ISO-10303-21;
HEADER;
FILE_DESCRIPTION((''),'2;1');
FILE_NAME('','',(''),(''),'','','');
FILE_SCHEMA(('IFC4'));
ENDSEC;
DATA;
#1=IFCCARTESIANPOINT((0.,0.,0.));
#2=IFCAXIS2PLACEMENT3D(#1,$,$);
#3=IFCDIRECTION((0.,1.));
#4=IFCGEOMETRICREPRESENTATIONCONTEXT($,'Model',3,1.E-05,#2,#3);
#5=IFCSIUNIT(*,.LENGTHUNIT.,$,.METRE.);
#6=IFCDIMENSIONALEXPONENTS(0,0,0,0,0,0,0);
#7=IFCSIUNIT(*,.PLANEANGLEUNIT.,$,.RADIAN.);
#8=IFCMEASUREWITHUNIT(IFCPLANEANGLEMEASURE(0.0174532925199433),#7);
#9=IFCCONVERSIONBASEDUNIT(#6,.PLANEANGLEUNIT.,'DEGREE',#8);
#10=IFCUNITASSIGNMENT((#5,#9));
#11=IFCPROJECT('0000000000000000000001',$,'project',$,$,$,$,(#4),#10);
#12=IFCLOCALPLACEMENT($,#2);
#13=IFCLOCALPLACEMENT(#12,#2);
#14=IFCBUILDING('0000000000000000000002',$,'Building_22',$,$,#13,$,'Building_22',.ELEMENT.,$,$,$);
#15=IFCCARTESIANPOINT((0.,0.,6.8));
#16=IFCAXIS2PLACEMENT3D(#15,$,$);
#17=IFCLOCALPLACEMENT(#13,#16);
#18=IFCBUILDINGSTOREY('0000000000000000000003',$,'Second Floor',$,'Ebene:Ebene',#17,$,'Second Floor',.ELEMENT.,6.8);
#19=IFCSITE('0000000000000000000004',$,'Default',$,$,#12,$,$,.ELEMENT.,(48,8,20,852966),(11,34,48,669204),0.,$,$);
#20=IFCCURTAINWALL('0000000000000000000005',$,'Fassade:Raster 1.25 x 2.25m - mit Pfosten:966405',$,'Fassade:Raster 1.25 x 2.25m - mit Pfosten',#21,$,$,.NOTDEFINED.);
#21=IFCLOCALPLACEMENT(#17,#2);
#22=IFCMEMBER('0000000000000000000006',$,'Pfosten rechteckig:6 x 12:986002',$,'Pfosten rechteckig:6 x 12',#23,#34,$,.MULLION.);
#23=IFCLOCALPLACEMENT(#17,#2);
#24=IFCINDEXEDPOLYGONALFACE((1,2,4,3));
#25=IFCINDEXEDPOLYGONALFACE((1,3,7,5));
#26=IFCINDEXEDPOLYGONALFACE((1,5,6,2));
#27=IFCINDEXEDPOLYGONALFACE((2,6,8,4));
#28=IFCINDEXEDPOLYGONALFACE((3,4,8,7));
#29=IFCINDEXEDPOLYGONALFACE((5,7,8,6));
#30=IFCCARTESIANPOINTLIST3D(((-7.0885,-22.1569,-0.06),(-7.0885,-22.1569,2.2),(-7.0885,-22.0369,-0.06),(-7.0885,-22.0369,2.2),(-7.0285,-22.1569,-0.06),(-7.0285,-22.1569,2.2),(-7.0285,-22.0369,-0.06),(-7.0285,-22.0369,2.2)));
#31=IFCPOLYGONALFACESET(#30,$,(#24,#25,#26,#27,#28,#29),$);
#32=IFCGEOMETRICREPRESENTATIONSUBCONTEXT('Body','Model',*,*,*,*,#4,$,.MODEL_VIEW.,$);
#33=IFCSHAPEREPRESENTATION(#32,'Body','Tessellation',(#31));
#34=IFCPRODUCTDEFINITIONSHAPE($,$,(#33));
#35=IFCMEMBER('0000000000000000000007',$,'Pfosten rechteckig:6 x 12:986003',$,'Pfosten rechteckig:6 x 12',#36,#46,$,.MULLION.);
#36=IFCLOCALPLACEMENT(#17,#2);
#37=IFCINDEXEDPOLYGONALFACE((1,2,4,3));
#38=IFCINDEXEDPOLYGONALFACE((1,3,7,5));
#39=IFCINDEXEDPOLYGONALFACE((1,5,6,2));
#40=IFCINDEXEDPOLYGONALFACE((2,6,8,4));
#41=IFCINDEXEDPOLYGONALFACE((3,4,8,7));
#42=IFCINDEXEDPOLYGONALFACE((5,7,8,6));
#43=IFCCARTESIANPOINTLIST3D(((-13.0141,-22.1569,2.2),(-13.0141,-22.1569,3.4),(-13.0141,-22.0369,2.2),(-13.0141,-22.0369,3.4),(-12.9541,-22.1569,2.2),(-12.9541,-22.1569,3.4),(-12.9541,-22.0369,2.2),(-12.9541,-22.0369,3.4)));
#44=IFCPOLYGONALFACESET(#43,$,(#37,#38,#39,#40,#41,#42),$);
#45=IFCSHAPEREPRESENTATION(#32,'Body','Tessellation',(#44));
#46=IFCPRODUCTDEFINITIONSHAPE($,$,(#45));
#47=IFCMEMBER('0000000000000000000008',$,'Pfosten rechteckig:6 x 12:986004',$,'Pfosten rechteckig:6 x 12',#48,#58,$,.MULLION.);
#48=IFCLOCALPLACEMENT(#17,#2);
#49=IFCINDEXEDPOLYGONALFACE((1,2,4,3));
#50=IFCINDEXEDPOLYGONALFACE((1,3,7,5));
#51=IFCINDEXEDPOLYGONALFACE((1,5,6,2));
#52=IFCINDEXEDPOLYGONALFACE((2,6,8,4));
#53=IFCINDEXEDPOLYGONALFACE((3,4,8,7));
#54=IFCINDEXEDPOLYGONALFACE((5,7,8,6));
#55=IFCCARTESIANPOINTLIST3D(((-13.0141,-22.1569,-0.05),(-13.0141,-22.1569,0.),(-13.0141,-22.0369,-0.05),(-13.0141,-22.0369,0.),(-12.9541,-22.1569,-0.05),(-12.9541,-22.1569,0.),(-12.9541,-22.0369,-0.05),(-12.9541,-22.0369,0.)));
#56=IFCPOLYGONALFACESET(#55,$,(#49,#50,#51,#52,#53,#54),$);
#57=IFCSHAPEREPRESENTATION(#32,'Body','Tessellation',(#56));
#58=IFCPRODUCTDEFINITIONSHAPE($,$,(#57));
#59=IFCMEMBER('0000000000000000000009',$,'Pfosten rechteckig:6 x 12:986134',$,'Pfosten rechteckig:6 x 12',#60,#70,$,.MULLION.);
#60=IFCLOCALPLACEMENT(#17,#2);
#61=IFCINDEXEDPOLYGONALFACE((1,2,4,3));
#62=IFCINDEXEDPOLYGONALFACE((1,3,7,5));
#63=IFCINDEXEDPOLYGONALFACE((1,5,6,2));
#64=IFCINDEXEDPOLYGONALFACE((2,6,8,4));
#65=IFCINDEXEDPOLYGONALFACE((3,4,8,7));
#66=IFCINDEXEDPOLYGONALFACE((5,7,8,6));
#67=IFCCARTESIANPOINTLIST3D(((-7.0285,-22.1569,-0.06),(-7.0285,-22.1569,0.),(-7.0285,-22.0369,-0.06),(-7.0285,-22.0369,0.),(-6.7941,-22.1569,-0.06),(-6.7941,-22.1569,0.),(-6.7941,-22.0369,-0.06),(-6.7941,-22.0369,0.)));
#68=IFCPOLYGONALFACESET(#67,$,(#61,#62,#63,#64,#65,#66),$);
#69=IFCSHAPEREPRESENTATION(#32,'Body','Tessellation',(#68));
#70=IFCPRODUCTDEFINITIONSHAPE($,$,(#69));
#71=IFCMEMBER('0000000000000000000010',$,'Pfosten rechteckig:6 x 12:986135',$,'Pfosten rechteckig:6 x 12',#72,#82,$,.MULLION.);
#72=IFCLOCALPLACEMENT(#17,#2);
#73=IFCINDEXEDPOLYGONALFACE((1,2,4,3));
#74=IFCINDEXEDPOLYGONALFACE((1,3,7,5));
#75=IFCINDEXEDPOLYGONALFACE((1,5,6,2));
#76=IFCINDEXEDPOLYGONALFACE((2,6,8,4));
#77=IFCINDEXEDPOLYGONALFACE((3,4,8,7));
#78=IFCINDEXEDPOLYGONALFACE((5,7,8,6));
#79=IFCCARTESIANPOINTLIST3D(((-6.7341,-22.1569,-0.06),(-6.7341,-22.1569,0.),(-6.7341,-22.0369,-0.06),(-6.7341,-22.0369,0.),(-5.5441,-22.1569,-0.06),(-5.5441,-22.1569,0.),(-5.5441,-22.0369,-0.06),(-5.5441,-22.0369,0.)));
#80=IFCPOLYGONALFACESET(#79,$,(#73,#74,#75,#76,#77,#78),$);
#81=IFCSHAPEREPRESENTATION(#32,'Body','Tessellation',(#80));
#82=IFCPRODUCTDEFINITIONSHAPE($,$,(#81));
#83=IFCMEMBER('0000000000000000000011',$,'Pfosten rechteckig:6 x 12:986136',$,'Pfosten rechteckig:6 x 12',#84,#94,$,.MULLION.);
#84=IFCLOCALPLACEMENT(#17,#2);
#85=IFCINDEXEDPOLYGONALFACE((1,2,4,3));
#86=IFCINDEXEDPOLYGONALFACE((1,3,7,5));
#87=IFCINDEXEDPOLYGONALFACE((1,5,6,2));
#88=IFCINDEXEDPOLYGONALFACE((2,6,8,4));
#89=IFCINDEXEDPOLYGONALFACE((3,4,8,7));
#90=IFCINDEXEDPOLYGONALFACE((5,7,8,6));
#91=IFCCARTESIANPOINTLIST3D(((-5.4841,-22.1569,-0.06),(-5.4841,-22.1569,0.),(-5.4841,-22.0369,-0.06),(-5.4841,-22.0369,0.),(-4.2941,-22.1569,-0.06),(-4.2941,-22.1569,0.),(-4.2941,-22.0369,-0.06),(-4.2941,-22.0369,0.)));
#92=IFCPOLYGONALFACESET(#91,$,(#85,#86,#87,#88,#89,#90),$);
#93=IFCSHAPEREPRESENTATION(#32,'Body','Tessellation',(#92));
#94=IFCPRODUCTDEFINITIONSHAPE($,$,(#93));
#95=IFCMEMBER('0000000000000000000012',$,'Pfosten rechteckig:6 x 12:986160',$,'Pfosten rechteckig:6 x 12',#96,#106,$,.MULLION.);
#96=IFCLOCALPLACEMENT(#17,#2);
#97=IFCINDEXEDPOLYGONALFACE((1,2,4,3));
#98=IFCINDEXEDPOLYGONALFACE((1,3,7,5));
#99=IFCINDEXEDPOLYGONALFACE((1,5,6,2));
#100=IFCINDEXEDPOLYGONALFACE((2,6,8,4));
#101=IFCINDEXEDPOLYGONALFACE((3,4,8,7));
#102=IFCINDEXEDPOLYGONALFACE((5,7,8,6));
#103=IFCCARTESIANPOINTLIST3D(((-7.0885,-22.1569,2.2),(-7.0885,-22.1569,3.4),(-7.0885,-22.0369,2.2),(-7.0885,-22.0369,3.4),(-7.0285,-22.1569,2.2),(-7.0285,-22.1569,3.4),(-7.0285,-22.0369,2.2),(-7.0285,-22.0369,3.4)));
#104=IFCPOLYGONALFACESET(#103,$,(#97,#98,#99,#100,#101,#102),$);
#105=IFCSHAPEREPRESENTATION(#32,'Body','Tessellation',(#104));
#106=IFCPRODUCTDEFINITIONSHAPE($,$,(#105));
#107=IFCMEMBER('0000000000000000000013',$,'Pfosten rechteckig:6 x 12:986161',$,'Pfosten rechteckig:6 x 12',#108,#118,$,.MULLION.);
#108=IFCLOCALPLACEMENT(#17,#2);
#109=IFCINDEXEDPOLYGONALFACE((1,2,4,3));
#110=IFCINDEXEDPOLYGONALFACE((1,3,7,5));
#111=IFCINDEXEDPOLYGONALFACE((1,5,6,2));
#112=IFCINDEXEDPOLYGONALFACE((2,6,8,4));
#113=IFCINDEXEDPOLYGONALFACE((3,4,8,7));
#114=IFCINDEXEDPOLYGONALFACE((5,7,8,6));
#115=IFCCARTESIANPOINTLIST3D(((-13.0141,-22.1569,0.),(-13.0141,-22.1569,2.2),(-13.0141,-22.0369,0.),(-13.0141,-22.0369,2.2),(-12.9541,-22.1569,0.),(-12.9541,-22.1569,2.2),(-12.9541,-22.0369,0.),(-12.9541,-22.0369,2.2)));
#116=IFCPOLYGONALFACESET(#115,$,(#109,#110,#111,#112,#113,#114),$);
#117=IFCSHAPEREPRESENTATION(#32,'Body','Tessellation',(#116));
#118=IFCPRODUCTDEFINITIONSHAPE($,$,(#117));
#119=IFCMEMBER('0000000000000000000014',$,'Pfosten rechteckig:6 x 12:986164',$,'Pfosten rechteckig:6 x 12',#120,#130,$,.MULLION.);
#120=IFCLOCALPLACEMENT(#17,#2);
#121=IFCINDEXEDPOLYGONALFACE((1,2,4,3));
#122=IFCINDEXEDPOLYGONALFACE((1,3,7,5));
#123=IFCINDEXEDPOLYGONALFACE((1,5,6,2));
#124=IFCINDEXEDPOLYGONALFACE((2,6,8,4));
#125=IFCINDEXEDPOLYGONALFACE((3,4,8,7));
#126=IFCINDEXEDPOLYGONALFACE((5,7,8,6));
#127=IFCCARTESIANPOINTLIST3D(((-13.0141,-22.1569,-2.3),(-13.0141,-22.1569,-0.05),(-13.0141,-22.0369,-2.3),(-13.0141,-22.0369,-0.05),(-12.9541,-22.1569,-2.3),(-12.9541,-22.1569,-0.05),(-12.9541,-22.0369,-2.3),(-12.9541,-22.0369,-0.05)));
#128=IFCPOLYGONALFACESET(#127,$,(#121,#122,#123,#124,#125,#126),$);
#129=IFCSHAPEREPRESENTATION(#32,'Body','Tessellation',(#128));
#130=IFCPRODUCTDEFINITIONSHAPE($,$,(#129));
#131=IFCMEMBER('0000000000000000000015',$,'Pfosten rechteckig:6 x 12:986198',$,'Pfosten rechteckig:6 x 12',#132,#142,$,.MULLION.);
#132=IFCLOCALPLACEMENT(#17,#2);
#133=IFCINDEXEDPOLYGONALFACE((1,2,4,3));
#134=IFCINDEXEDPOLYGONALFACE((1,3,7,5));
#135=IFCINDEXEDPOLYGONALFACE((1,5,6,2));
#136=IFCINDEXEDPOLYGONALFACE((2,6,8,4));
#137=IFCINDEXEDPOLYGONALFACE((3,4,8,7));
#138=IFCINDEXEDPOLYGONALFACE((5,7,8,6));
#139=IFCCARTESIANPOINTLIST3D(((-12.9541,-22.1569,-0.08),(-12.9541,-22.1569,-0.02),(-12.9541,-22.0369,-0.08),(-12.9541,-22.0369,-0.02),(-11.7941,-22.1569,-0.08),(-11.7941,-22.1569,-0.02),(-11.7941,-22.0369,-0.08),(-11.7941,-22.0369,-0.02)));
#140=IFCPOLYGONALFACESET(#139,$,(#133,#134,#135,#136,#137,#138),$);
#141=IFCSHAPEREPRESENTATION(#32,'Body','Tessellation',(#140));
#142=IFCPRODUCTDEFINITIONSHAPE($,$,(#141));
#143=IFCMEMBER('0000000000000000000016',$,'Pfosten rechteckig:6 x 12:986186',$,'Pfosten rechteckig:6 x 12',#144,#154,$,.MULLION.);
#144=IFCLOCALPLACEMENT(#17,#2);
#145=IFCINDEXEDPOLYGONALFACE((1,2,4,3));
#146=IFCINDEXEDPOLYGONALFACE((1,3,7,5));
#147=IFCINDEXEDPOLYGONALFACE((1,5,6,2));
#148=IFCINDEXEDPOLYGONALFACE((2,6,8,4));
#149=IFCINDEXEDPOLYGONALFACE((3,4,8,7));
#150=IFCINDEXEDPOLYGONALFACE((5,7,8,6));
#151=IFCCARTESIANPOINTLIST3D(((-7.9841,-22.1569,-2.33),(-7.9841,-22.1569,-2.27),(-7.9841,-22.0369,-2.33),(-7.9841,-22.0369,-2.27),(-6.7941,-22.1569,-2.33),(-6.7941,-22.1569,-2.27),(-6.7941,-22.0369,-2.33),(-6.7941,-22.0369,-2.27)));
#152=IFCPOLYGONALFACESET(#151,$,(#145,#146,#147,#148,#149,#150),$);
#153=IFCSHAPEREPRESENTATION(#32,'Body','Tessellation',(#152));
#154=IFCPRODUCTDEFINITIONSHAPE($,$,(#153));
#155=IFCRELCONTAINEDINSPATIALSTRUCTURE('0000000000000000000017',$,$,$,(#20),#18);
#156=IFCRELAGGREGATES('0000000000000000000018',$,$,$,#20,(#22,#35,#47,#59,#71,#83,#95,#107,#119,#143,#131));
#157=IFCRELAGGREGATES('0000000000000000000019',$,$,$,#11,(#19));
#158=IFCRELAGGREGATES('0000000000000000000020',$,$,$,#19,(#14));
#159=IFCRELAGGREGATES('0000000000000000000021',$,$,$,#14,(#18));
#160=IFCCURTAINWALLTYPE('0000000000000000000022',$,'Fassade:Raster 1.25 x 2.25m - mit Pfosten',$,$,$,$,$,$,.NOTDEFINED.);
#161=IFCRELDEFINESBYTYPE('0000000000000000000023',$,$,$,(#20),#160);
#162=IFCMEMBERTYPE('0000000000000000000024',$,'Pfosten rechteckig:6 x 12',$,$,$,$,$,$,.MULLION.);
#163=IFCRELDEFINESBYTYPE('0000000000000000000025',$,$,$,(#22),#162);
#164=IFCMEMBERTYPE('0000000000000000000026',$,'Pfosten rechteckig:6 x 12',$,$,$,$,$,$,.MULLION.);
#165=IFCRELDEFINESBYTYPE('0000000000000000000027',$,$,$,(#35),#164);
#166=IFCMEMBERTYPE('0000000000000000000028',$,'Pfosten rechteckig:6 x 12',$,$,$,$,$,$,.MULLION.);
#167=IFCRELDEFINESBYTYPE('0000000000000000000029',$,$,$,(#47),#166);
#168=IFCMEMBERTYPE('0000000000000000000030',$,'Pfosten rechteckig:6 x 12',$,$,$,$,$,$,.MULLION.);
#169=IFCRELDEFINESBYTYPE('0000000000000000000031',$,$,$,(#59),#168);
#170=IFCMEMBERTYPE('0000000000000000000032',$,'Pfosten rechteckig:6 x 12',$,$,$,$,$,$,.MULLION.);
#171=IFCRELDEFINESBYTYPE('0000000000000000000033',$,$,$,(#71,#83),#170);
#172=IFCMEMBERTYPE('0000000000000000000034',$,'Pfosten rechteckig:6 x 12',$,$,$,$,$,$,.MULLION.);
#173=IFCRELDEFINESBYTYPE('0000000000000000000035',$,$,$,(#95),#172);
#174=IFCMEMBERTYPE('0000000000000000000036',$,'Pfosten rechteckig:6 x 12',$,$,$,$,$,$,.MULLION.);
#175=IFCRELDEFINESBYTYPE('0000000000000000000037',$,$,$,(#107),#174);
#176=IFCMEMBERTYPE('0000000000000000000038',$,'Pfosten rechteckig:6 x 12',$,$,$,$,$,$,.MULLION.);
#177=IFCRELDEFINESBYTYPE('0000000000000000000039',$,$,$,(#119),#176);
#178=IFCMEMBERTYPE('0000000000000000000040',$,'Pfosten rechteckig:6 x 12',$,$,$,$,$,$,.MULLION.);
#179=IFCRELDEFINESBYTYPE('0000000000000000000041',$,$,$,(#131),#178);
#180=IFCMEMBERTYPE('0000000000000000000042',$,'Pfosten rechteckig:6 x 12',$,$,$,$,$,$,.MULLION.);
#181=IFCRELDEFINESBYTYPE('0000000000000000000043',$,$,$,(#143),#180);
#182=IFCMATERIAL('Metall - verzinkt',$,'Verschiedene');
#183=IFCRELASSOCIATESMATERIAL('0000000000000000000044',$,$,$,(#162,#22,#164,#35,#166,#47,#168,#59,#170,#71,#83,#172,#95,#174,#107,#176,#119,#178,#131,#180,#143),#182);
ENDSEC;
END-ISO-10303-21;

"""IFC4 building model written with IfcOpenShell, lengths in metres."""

from ifc_helpers import new_model, entity, si_unit, converted_unit, direction, frame, origin, place, context, subcontext, project, spatial, indexed_curve, outline, extrude, source, transform, mapped, material, type_object, type_shapes, element, aggregate, save


model = new_model("IFC4")

# Units and contexts
model_context = context("Model", 3, precision=1e-05, world=origin(), true_north=direction((0.0, 1.0)))
body_context = subcontext(model_context, "Body", "Model", "MODEL_VIEW")
ifc_project = project(units=[si_unit("LENGTHUNIT", "METRE"), converted_unit("PLANEANGLEUNIT", "DEGREE", entity("IfcPlaneAngleMeasure", 0.0174532925199433), si_unit("PLANEANGLEUNIT", "RADIAN"), dimensions=[0, 0, 0, 0, 0, 0, 0])], contexts=[model_context])

# Site, building, storey
site_placement = place(None, origin())
site = spatial("IfcSite", under=ifc_project, at=site_placement, Name="Default", CompositionType="ELEMENT", RefLatitude=(48, 8, 20, 852966), RefLongitude=(11, 34, 48, 669204), RefElevation=0.0)
building_placement = place(site_placement, origin())
building = spatial("IfcBuilding", under=site, at=building_placement, Name="Building_22", LongName="Building_22", CompositionType="ELEMENT")
storey_placement = place(building_placement, frame((0.0, 0.0, 6.8)))
storey = spatial("IfcBuildingStorey", under=building, at=storey_placement, Name="Second Floor", ObjectType="Ebene:Ebene", LongName="Second Floor", CompositionType="ELEMENT", Elevation=6.8)

# Curtain wall, members
curtain_wall_type = type_object("IfcCurtainWallType", Name="Fassade:Raster 1.25 x 2.25m - mit Pfosten", PredefinedType="NOTDEFINED")
curtain_wall_placement = place(storey_placement, frame((0.0, 0.0, -6.8)))
curtain_wall = element("IfcCurtainWall", 1, at=curtain_wall_placement, inside=storey, type_object=curtain_wall_type, Name="Fassade:Raster 1.25 x 2.25m - mit Pfosten:966405", ObjectType="Fassade:Raster 1.25 x 2.25m - mit Pfosten", PredefinedType="NOTDEFINED")
ifc_material_1 = material(Name="Metall - verzinkt", Category="Verschiedene")
member_type_1 = type_object("IfcMemberType", Name="Pfosten rechteckig:6 x 12", PredefinedType="MULLION", material=ifc_material_1)
shared_shape_1 = source(origin(), body_context, "Body", "SweptSolid", [
    extrude(outline(indexed_curve([(-0.03, -0.06), (0.03, -0.06), (0.03, 0.06), (-0.03, 0.06), (-0.03, -0.06)], self_intersect=False)), frame((-0.03, 0.0, -2.26), z_axis=(0.0, 0.0, 1.0), x_axis=(-1.0, 0.0, 0.0)), (0.0, 0.0, 1.0), 2.26),
])
type_shapes(member_type_1, [shared_shape_1])
member_1_placement = place(curtain_wall_placement, frame((-7.0285, -22.0969, 6.74), z_axis=(0.0, 0.0, -1.0), x_axis=(1.0, 0.0, 0.0)))
member_1 = element("IfcMember", 2, at=member_1_placement, type_object=member_type_1, material=ifc_material_1, Name="Pfosten rechteckig:6 x 12:986002", ObjectType="Pfosten rechteckig:6 x 12", PredefinedType="MULLION", context=body_context, shape_type="MappedRepresentation", body=[
    mapped(shared_shape_1, transform((0.0, 0.0, 0.0), scale=1.0)),
])
member_type_2 = type_object("IfcMemberType", Name="Pfosten rechteckig:6 x 12", PredefinedType="MULLION", material=ifc_material_1)
shared_shape_2 = source(origin(), body_context, "Body", "SweptSolid", [
    extrude(outline(indexed_curve([(-0.03, -0.06), (0.03, -0.06), (0.03, 0.06), (-0.03, 0.06), (-0.03, -0.06)], self_intersect=False)), frame((-0.03, 0.0, -1.2), z_axis=(0.0, 0.0, 1.0), x_axis=(-1.0, 0.0, 0.0)), (0.0, 0.0, 1.0), 1.2),
])
type_shapes(member_type_2, [shared_shape_2])
member_2_placement = place(curtain_wall_placement, frame((-13.0141, -22.0969, 10.2), z_axis=(0.0, 0.0, 1.0), x_axis=(-1.0, 0.0, 0.0)))
member_2 = element("IfcMember", 3, at=member_2_placement, type_object=member_type_2, material=ifc_material_1, Name="Pfosten rechteckig:6 x 12:986003", ObjectType="Pfosten rechteckig:6 x 12", PredefinedType="MULLION", context=body_context, shape_type="MappedRepresentation", body=[
    mapped(shared_shape_2, transform((0.0, 0.0, 0.0), scale=1.0)),
])
member_type_3 = type_object("IfcMemberType", Name="Pfosten rechteckig:6 x 12", PredefinedType="MULLION", material=ifc_material_1)
shared_shape_3 = source(origin(), body_context, "Body", "SweptSolid", [
    extrude(outline(indexed_curve([(-0.03, -0.06), (0.03, -0.06), (0.03, 0.06), (-0.03, 0.06), (-0.03, -0.06)], self_intersect=False)), frame((-0.03, 0.0, -0.05), z_axis=(0.0, 0.0, 1.0), x_axis=(-1.0, 0.0, 0.0)), (0.0, 0.0, 1.0), 0.05),
])
type_shapes(member_type_3, [shared_shape_3])
member_3_placement = place(curtain_wall_placement, frame((-13.0141, -22.0969, 6.8), z_axis=(0.0, 0.0, 1.0), x_axis=(-1.0, 0.0, 0.0)))
member_3 = element("IfcMember", 4, at=member_3_placement, type_object=member_type_3, material=ifc_material_1, Name="Pfosten rechteckig:6 x 12:986004", ObjectType="Pfosten rechteckig:6 x 12", PredefinedType="MULLION", context=body_context, shape_type="MappedRepresentation", body=[
    mapped(shared_shape_3, transform((0.0, 0.0, 0.0), scale=1.0)),
])
member_type_4 = type_object("IfcMemberType", Name="Pfosten rechteckig:6 x 12", PredefinedType="MULLION", material=ifc_material_1)
shared_shape_4 = source(origin(), body_context, "Body", "SweptSolid", [
    extrude(outline(indexed_curve([(-0.03, -0.06), (0.03, -0.06), (0.03, 0.06), (-0.03, 0.06), (-0.03, -0.06)], self_intersect=False)), frame((-0.03, 0.0, -0.2344), z_axis=(0.0, 0.0, 1.0), x_axis=(-1.0, 0.0, 0.0)), (0.0, 0.0, 1.0), 0.2344),
])
type_shapes(member_type_4, [shared_shape_4])
member_4_placement = place(curtain_wall_placement, frame((-6.7941, -22.0969, 6.8), z_axis=(1.0, 0.0, 0.0), x_axis=(0.0, 0.0, 1.0)))
member_4 = element("IfcMember", 5, at=member_4_placement, type_object=member_type_4, material=ifc_material_1, Name="Pfosten rechteckig:6 x 12:986134", ObjectType="Pfosten rechteckig:6 x 12", PredefinedType="MULLION", context=body_context, shape_type="MappedRepresentation", body=[
    mapped(shared_shape_4, transform((0.0, 0.0, 0.0), scale=1.0)),
])
member_type_5 = type_object("IfcMemberType", Name="Pfosten rechteckig:6 x 12", PredefinedType="MULLION", material=ifc_material_1)
shared_shape_5 = source(origin(), body_context, "Body", "SweptSolid", [
    extrude(outline(indexed_curve([(-0.03, -0.06), (0.03, -0.06), (0.03, 0.06), (-0.03, 0.06), (-0.03, -0.06)], self_intersect=False)), frame((-0.03, 0.0, -1.19), z_axis=(0.0, 0.0, 1.0), x_axis=(-1.0, 0.0, 0.0)), (0.0, 0.0, 1.0), 1.19),
])
type_shapes(member_type_5, [shared_shape_5])
member_5_placement = place(curtain_wall_placement, frame((-5.5441, -22.0969, 6.8), z_axis=(1.0, 0.0, 0.0), x_axis=(0.0, 0.0, 1.0)))
member_5 = element("IfcMember", 6, at=member_5_placement, type_object=member_type_5, material=ifc_material_1, Name="Pfosten rechteckig:6 x 12:986135", ObjectType="Pfosten rechteckig:6 x 12", PredefinedType="MULLION", context=body_context, shape_type="MappedRepresentation", body=[
    mapped(shared_shape_5, transform((0.0, 0.0, 0.0), scale=1.0)),
])
member_6_placement = place(curtain_wall_placement, frame((-4.2941, -22.0969, 6.8), z_axis=(1.0, 0.0, 0.0), x_axis=(0.0, 0.0, 1.0)))
member_6 = element("IfcMember", 7, at=member_6_placement, type_object=member_type_5, material=ifc_material_1, Name="Pfosten rechteckig:6 x 12:986136", ObjectType="Pfosten rechteckig:6 x 12", PredefinedType="MULLION", context=body_context, shape_type="MappedRepresentation", body=[
    mapped(shared_shape_5, transform((0.0, 0.0, 0.0), scale=1.0)),
])
member_type_6 = type_object("IfcMemberType", Name="Pfosten rechteckig:6 x 12", PredefinedType="MULLION", material=ifc_material_1)
shared_shape_6 = source(origin(), body_context, "Body", "SweptSolid", [
    extrude(outline(indexed_curve([(-0.03, -0.06), (0.03, -0.06), (0.03, 0.06), (-0.03, 0.06), (-0.03, -0.06)], self_intersect=False)), frame((-0.03, 0.0, -1.2), z_axis=(0.0, 0.0, 1.0), x_axis=(-1.0, 0.0, 0.0)), (0.0, 0.0, 1.0), 1.2),
])
type_shapes(member_type_6, [shared_shape_6])
member_7_placement = place(curtain_wall_placement, frame((-7.0285, -22.0969, 9.0), z_axis=(0.0, 0.0, -1.0), x_axis=(1.0, 0.0, 0.0)))
member_7 = element("IfcMember", 8, at=member_7_placement, type_object=member_type_6, material=ifc_material_1, Name="Pfosten rechteckig:6 x 12:986160", ObjectType="Pfosten rechteckig:6 x 12", PredefinedType="MULLION", context=body_context, shape_type="MappedRepresentation", body=[
    mapped(shared_shape_6, transform((0.0, 0.0, 0.0), scale=1.0)),
])
member_type_7 = type_object("IfcMemberType", Name="Pfosten rechteckig:6 x 12", PredefinedType="MULLION", material=ifc_material_1)
shared_shape_7 = source(origin(), body_context, "Body", "SweptSolid", [
    extrude(outline(indexed_curve([(-0.03, -0.06), (0.03, -0.06), (0.03, 0.06), (-0.03, 0.06), (-0.03, -0.06)], self_intersect=False)), frame((-0.03, 0.0, -2.2), z_axis=(0.0, 0.0, 1.0), x_axis=(-1.0, 0.0, 0.0)), (0.0, 0.0, 1.0), 2.2),
])
type_shapes(member_type_7, [shared_shape_7])
member_8_placement = place(curtain_wall_placement, frame((-13.0141, -22.0969, 9.0), z_axis=(0.0, 0.0, 1.0), x_axis=(-1.0, 0.0, 0.0)))
member_8 = element("IfcMember", 9, at=member_8_placement, type_object=member_type_7, material=ifc_material_1, Name="Pfosten rechteckig:6 x 12:986161", ObjectType="Pfosten rechteckig:6 x 12", PredefinedType="MULLION", context=body_context, shape_type="MappedRepresentation", body=[
    mapped(shared_shape_7, transform((0.0, 0.0, 0.0), scale=1.0)),
])
member_type_8 = type_object("IfcMemberType", Name="Pfosten rechteckig:6 x 12", PredefinedType="MULLION", material=ifc_material_1)
shared_shape_8 = source(origin(), body_context, "Body", "SweptSolid", [
    extrude(outline(indexed_curve([(-0.03, -0.06), (0.03, -0.06), (0.03, 0.06), (-0.03, 0.06), (-0.03, -0.06)], self_intersect=False)), frame((-0.03, 0.0, -2.25), z_axis=(0.0, 0.0, 1.0), x_axis=(-1.0, 0.0, 0.0)), (0.0, 0.0, 1.0), 2.25),
])
type_shapes(member_type_8, [shared_shape_8])
member_9_placement = place(curtain_wall_placement, frame((-13.0141, -22.0969, 6.75), z_axis=(0.0, 0.0, 1.0), x_axis=(-1.0, 0.0, 0.0)))
member_9 = element("IfcMember", 10, at=member_9_placement, type_object=member_type_8, material=ifc_material_1, Name="Pfosten rechteckig:6 x 12:986164", ObjectType="Pfosten rechteckig:6 x 12", PredefinedType="MULLION", context=body_context, shape_type="MappedRepresentation", body=[
    mapped(shared_shape_8, transform((0.0, 0.0, 0.0), scale=1.0)),
])
member_type_9 = type_object("IfcMemberType", Name="Pfosten rechteckig:6 x 12", PredefinedType="MULLION", material=ifc_material_1)
shared_shape_9 = source(origin(), body_context, "Body", "SweptSolid", [
    extrude(outline(indexed_curve([(-0.03, -0.06), (0.03, -0.06), (0.03, 0.06), (-0.03, 0.06), (-0.03, -0.06)], self_intersect=False)), frame((0.0, 0.0, -1.16), z_axis=(0.0, 0.0, 1.0), x_axis=(-1.0, 0.0, 0.0)), (0.0, 0.0, 1.0), 1.16),
])
type_shapes(member_type_9, [shared_shape_9])
member_10_placement = place(curtain_wall_placement, frame((-11.7941, -22.0969, 6.75), z_axis=(1.0, 0.0, 0.0), x_axis=(0.0, 0.0, 1.0)))
member_10 = element("IfcMember", 11, at=member_10_placement, type_object=member_type_9, material=ifc_material_1, Name="Pfosten rechteckig:6 x 12:986198", ObjectType="Pfosten rechteckig:6 x 12", PredefinedType="MULLION", context=body_context, shape_type="MappedRepresentation", body=[
    mapped(shared_shape_9, transform((0.0, 0.0, 0.0), scale=1.0)),
])
member_type_10 = type_object("IfcMemberType", Name="Pfosten rechteckig:6 x 12", PredefinedType="MULLION", material=ifc_material_1)
shared_shape_10 = source(origin(), body_context, "Body", "SweptSolid", [
    extrude(outline(indexed_curve([(-0.03, -0.06), (0.03, -0.06), (0.03, 0.06), (-0.03, 0.06), (-0.03, -0.06)], self_intersect=False)), frame((0.0, 0.0, -1.19), z_axis=(0.0, 0.0, 1.0), x_axis=(-1.0, 0.0, 0.0)), (0.0, 0.0, 1.0), 1.19),
])
type_shapes(member_type_10, [shared_shape_10])
member_11_placement = place(curtain_wall_placement, frame((-6.7941, -22.0969, 4.5), z_axis=(1.0, 0.0, 0.0), x_axis=(0.0, 0.0, 1.0)))
member_11 = element("IfcMember", 12, at=member_11_placement, type_object=member_type_10, material=ifc_material_1, Name="Pfosten rechteckig:6 x 12:986186", ObjectType="Pfosten rechteckig:6 x 12", PredefinedType="MULLION", context=body_context, shape_type="MappedRepresentation", body=[
    mapped(shared_shape_10, transform((0.0, 0.0, 0.0), scale=1.0)),
])
aggregate(curtain_wall, [member_1, member_2, member_3, member_4, member_5, member_6, member_7, member_8, member_9, member_11, member_10])

save(model, "model.ifc")
